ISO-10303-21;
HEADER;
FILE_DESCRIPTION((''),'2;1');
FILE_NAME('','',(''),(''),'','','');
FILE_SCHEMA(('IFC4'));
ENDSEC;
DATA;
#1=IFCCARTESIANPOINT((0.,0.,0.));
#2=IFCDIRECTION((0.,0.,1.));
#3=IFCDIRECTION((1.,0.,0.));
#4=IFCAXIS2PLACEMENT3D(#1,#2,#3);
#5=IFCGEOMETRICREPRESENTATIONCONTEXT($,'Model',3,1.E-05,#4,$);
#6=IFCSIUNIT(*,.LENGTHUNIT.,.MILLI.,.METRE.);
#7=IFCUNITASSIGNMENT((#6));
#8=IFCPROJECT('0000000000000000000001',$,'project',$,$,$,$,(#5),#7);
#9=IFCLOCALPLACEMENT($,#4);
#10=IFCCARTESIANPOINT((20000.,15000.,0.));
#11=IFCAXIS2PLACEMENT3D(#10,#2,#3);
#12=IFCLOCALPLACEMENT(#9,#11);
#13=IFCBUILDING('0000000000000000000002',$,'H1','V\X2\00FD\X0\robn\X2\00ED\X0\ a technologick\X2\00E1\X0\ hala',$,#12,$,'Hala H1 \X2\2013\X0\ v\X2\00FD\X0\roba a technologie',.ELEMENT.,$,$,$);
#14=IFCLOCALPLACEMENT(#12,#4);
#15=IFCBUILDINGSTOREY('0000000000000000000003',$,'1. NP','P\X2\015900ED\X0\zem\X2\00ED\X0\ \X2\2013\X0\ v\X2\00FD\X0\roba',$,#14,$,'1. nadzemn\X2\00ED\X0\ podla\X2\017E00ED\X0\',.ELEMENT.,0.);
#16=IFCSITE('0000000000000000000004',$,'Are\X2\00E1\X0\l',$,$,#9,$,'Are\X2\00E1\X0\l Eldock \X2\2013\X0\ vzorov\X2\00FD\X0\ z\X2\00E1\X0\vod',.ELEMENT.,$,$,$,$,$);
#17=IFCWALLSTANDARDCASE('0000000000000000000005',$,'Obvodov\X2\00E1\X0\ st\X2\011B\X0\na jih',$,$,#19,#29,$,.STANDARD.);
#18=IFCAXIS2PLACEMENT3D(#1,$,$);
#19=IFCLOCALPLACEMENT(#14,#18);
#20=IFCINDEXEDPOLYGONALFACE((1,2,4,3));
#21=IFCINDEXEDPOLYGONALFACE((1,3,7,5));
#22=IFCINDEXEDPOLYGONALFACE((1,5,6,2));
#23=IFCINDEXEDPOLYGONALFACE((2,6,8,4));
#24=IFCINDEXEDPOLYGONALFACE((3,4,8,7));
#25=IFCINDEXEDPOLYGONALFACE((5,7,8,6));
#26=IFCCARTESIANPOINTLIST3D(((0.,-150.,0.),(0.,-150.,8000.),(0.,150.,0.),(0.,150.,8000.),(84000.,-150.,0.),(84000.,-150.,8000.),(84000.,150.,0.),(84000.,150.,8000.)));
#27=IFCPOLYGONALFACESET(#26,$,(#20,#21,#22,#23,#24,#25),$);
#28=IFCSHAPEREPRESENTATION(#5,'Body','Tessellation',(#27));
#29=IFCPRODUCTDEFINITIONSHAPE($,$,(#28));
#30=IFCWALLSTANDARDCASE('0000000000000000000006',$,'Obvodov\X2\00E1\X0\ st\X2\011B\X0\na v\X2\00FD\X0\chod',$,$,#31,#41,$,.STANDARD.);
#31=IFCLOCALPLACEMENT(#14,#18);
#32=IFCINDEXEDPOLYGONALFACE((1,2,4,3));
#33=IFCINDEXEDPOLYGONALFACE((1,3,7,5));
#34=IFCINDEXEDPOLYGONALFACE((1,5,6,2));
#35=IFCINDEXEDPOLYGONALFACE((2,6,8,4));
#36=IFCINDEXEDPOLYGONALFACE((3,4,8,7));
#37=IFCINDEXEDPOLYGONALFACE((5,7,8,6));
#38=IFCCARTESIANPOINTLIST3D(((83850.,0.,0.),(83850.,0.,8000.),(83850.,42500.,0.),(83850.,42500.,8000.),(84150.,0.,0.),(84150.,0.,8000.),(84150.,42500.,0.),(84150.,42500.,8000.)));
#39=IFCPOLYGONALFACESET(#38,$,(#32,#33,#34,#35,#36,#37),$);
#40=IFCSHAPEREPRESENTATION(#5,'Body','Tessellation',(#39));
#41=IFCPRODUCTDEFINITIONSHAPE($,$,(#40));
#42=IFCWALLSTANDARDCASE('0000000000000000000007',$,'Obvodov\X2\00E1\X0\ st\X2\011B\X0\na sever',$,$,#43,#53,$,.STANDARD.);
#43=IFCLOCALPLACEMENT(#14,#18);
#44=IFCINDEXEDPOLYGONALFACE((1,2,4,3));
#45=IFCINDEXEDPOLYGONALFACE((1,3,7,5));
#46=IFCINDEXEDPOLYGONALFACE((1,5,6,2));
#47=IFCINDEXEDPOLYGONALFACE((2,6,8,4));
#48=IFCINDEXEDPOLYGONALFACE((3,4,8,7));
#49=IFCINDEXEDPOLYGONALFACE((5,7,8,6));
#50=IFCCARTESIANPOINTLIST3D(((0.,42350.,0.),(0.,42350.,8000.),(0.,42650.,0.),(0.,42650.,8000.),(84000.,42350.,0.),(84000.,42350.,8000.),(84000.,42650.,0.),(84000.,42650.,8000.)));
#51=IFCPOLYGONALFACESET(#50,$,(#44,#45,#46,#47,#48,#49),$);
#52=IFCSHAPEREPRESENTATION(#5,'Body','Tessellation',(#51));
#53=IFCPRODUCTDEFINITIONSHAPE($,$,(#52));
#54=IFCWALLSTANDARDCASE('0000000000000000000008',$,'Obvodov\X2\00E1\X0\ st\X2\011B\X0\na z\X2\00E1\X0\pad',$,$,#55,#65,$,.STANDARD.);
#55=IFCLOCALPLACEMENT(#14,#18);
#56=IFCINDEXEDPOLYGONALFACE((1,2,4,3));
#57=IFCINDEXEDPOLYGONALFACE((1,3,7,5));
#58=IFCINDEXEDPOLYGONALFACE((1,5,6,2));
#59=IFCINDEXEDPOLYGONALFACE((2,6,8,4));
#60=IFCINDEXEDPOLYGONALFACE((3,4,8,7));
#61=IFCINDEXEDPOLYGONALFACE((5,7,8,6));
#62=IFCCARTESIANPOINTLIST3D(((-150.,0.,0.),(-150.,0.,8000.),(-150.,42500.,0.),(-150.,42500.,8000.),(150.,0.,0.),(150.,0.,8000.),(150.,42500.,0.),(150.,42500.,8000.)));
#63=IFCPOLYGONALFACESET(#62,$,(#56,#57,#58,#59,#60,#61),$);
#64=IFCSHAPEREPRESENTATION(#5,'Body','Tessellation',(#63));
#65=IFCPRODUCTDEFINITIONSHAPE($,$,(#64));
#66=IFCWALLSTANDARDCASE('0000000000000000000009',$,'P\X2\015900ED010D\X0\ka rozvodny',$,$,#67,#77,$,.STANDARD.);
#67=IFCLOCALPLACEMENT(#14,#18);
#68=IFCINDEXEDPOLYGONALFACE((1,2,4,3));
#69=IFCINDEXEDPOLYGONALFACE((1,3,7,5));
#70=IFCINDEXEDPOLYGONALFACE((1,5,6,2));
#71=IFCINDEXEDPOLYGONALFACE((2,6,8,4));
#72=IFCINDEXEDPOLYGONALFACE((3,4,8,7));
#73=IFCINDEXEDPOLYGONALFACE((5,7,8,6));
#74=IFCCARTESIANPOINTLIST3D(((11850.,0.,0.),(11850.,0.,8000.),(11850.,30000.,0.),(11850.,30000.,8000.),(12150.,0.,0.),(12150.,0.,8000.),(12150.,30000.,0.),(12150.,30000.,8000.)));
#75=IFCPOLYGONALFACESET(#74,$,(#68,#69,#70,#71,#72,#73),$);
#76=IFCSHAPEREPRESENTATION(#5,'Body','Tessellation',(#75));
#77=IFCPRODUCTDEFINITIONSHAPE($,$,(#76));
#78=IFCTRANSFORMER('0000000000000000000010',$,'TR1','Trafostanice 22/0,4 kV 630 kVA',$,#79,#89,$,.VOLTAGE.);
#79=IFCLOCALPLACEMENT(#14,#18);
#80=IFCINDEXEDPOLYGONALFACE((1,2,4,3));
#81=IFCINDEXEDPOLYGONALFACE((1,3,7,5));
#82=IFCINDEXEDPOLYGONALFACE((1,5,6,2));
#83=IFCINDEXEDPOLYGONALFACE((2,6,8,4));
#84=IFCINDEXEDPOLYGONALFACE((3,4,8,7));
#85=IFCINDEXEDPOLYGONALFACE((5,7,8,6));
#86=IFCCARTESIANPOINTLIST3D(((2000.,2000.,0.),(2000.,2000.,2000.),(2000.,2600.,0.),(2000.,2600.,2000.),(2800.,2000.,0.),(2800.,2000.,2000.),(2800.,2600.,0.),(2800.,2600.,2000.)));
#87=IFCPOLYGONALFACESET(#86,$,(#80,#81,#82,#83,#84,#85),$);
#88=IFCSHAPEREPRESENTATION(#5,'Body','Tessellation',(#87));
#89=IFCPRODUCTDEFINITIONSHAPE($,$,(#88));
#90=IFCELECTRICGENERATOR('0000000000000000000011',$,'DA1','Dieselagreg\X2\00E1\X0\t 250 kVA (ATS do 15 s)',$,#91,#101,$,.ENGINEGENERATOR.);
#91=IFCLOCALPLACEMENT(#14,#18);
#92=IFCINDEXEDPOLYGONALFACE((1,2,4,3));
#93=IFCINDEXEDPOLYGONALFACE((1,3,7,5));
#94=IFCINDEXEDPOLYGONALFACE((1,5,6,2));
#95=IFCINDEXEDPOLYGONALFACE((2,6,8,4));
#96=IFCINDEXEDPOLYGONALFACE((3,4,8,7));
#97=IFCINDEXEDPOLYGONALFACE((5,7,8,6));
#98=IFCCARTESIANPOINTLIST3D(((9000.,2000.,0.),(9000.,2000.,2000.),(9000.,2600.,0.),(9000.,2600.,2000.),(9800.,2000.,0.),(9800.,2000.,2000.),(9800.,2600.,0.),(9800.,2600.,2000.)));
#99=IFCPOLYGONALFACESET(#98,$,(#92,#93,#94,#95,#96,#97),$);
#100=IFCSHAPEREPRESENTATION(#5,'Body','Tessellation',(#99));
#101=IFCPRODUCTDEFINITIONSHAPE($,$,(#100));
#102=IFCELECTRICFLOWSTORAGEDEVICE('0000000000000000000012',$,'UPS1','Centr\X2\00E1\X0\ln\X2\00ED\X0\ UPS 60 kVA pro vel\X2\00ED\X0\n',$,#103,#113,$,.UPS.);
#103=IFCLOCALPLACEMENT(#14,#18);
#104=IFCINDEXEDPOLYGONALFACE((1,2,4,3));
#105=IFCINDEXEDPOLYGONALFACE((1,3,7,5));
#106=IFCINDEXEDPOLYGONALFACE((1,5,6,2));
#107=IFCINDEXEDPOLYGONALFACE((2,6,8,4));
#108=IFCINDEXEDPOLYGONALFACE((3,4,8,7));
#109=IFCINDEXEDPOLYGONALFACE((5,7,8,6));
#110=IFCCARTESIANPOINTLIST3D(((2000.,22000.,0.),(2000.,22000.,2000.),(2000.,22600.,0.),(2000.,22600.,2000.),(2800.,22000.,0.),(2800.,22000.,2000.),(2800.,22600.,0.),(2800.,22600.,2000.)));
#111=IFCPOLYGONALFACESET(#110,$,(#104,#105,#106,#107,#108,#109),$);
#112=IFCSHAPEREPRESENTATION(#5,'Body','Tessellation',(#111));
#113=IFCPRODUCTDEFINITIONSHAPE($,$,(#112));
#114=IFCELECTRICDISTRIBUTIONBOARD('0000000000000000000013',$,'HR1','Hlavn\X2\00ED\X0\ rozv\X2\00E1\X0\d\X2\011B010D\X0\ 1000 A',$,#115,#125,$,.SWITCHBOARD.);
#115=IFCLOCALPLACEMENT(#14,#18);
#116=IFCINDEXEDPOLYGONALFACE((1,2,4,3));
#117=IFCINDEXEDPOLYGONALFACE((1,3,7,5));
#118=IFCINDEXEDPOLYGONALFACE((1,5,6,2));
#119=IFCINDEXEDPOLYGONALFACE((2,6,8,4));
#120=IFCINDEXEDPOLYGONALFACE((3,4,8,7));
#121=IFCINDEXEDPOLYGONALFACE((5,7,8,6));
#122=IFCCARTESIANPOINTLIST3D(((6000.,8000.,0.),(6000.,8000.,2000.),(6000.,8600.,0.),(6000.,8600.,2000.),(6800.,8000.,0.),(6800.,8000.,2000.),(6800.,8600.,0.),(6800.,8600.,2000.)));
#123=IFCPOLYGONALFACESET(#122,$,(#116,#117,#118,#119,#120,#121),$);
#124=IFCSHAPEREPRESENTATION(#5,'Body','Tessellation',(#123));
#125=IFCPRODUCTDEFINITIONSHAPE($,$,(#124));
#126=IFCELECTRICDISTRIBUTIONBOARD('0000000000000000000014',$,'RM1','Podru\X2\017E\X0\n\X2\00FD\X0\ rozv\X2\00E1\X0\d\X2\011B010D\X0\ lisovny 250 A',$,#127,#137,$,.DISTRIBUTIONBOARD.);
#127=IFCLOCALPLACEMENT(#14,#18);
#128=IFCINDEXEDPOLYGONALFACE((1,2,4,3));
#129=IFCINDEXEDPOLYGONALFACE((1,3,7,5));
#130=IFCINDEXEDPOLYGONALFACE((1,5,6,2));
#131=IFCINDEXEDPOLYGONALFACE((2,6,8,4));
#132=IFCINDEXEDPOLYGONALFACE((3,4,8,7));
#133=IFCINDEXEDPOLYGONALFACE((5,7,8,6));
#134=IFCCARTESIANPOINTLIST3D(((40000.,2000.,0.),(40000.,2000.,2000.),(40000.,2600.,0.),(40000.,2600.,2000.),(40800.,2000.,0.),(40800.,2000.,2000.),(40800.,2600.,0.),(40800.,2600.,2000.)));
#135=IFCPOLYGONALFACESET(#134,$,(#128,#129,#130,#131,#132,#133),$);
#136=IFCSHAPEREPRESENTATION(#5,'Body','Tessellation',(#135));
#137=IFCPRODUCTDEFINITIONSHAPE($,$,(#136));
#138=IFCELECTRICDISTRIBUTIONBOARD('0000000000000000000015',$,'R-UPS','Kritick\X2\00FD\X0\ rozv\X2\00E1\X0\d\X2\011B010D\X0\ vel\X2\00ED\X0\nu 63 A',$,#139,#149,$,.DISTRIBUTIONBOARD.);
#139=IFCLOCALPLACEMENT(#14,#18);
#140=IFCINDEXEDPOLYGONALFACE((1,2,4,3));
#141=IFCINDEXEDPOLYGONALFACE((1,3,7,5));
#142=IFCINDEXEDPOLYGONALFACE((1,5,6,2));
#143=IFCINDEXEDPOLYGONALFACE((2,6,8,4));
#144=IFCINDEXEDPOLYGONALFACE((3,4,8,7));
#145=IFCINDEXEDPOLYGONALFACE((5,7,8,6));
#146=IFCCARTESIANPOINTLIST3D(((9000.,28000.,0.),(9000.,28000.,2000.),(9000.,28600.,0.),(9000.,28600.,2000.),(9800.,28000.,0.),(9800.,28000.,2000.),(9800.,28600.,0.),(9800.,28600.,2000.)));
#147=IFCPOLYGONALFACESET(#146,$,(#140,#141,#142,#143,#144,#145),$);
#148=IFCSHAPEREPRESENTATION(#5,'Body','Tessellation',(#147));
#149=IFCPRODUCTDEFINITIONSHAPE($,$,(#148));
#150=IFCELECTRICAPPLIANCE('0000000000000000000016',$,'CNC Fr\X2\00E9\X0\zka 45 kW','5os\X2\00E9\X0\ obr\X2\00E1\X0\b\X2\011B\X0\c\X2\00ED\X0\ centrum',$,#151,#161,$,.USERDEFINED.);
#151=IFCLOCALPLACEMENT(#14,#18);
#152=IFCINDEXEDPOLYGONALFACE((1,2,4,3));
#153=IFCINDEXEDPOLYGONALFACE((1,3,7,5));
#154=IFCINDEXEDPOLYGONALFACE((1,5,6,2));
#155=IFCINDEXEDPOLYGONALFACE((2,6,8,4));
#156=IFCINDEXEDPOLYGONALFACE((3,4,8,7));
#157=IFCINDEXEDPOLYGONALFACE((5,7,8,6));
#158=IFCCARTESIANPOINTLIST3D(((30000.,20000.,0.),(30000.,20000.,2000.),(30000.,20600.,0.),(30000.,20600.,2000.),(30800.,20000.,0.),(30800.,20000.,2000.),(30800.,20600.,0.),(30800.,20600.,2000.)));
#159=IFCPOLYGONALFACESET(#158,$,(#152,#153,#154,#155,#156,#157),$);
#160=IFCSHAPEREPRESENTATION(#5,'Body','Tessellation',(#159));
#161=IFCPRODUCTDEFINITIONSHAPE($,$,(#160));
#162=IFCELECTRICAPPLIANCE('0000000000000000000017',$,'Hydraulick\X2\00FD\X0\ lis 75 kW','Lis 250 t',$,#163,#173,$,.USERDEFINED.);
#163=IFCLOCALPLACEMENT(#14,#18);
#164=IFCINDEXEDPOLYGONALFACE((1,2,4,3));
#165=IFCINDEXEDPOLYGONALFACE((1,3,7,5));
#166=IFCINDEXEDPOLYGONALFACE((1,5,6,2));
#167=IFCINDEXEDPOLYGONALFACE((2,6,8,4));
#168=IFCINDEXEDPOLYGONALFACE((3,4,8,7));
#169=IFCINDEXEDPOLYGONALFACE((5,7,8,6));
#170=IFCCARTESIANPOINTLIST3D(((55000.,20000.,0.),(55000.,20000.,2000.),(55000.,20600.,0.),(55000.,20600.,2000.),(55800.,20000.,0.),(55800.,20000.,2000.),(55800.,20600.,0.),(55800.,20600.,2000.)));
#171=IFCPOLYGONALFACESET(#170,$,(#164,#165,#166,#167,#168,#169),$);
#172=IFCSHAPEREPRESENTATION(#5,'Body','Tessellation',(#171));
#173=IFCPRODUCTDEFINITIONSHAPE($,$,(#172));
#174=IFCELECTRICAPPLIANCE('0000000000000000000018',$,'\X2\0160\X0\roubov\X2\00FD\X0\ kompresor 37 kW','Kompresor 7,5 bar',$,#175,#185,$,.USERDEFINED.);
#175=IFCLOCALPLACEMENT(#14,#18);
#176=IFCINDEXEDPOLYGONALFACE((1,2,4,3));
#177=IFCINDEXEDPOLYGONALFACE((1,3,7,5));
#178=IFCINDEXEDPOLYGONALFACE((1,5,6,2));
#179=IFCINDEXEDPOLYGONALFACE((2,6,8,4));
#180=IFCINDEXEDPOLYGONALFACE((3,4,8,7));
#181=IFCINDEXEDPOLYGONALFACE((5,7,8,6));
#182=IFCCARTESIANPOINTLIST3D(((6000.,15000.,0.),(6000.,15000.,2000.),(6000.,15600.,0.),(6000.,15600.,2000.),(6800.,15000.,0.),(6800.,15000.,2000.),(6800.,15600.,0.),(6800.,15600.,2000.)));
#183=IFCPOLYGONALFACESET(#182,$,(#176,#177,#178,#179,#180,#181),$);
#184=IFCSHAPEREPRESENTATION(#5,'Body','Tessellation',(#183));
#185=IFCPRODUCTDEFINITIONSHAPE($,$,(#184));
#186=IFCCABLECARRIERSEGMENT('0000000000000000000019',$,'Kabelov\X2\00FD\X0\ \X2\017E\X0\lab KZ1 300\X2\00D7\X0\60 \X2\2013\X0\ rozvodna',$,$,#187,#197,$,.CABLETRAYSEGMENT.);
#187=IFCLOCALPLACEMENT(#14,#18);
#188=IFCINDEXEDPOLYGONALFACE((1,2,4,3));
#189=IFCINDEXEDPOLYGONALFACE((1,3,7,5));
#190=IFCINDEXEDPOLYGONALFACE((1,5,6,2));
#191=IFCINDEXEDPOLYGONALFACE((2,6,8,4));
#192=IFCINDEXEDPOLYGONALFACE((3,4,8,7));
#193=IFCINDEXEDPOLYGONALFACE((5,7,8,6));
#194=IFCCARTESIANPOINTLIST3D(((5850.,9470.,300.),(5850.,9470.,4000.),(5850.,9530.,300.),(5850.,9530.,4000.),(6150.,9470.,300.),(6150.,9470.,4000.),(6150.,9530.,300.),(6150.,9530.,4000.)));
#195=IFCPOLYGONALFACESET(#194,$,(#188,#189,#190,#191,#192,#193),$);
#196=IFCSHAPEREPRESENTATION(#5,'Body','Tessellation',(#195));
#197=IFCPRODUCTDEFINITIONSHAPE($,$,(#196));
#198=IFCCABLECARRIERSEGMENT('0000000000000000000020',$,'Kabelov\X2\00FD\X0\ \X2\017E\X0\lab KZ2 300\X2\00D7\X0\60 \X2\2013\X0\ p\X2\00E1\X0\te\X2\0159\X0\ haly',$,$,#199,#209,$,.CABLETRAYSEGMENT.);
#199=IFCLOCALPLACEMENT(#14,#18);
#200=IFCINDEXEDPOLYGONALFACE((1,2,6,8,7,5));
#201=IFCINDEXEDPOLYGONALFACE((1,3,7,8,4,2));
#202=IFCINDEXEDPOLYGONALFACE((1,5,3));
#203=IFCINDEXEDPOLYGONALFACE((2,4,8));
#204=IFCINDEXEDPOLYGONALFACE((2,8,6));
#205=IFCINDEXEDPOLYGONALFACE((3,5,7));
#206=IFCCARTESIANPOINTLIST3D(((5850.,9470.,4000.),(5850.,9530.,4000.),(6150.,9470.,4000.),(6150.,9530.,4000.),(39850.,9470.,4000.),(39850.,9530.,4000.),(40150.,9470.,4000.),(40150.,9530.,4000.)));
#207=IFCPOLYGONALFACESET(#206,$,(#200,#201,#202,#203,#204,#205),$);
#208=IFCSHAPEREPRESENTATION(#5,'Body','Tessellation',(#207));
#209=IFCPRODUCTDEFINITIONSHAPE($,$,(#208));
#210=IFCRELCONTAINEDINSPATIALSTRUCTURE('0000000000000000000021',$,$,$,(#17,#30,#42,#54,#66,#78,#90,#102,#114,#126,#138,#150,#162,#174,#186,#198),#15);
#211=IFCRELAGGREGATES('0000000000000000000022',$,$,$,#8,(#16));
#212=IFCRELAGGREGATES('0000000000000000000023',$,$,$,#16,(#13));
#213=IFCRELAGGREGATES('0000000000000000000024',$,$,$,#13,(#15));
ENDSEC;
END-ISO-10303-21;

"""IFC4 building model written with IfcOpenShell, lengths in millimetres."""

from ifc_helpers import new_model, si_unit, frame, frame_2d, origin_with_axes, origin_2d, place, context, project, spatial, rectangle, extrude, element, save


model = new_model("IFC4")

# Units and contexts
model_context = context("Model", 3, precision=1e-05, world=origin_with_axes())
ifc_project = project(units=[si_unit("LENGTHUNIT", "METRE", prefix="MILLI")], contexts=[model_context])

# Site, building, storey
site_placement = place(None, origin_with_axes())
site = spatial("IfcSite", under=ifc_project, at=site_placement, Name="Areál", LongName="Areál Eldock – vzorový závod", CompositionType="ELEMENT")
building_placement = place(site_placement, frame((20000.0, 15000.0, 0.0), z_axis=(0.0, 0.0, 1.0), x_axis=(1.0, 0.0, 0.0)))
building = spatial("IfcBuilding", under=site, at=building_placement, Name="H1", Description="Výrobní a technologická hala", LongName="Hala H1 – výroba a technologie", CompositionType="ELEMENT")
storey_placement = place(building_placement, origin_with_axes())
storey = spatial("IfcBuildingStorey", under=building, at=storey_placement, Name="1. NP", Description="Přízemí – výroba", LongName="1. nadzemní podlaží", CompositionType="ELEMENT", Elevation=0.0)

# Walls
wall_1_placement = place(storey_placement, origin_with_axes())
element("IfcWallStandardCase", 1, at=wall_1_placement, inside=storey, Name="Obvodová stěna jih", PredefinedType="STANDARD", context=model_context, shape_type="SweptSolid", body=[
    extrude(rectangle(XDim=84000.0, YDim=300.0, at=frame_2d((42000.0, 0.0))), origin_with_axes(), (0.0, 0.0, 1.0), 8000.0),
])
wall_2_placement = place(storey_placement, frame((84000.0, 0.0, 0.0), z_axis=(0.0, 0.0, 1.0), x_axis=(0.0, 1.0, 0.0)))
element("IfcWallStandardCase", 2, at=wall_2_placement, inside=storey, Name="Obvodová stěna východ", PredefinedType="STANDARD", context=model_context, shape_type="SweptSolid", body=[
    extrude(rectangle(XDim=42500.0, YDim=300.0, at=frame_2d((21250.0, 0.0))), origin_with_axes(), (0.0, 0.0, 1.0), 8000.0),
])
wall_3_placement = place(storey_placement, frame((84000.0, 42500.0, 0.0), z_axis=(0.0, 0.0, 1.0), x_axis=(-1.0, 0.0, 0.0)))
element("IfcWallStandardCase", 3, at=wall_3_placement, inside=storey, Name="Obvodová stěna sever", PredefinedType="STANDARD", context=model_context, shape_type="SweptSolid", body=[
    extrude(rectangle(XDim=84000.0, YDim=300.0, at=frame_2d((42000.0, 0.0))), origin_with_axes(), (0.0, 0.0, 1.0), 8000.0),
])
wall_4_placement = place(storey_placement, frame((0.0, 42500.0, 0.0), z_axis=(0.0, 0.0, 1.0), x_axis=(0.0, -1.0, 0.0)))
element("IfcWallStandardCase", 4, at=wall_4_placement, inside=storey, Name="Obvodová stěna západ", PredefinedType="STANDARD", context=model_context, shape_type="SweptSolid", body=[
    extrude(rectangle(XDim=42500.0, YDim=300.0, at=frame_2d((21250.0, 0.0))), origin_with_axes(), (0.0, 0.0, 1.0), 8000.0),
])
wall_5_placement = place(storey_placement, frame((12000.0, 0.0, 0.0), z_axis=(0.0, 0.0, 1.0), x_axis=(0.0, 1.0, 0.0)))
element("IfcWallStandardCase", 5, at=wall_5_placement, inside=storey, Name="Příčka rozvodny", PredefinedType="STANDARD", context=model_context, shape_type="SweptSolid", body=[
    extrude(rectangle(XDim=30000.0, YDim=300.0, at=frame_2d((15000.0, 0.0))), origin_with_axes(), (0.0, 0.0, 1.0), 8000.0),
])

# Transformer
transformer_placement = place(storey_placement, frame((2000.0, 2000.0, 0.0), z_axis=(0.0, 0.0, 1.0), x_axis=(1.0, 0.0, 0.0)))
element("IfcTransformer", 6, at=transformer_placement, inside=storey, Name="TR1", Description="Trafostanice 22/0,4 kV 630 kVA", PredefinedType="VOLTAGE", context=model_context, shape_type="SweptSolid", body=[
    extrude(rectangle(XDim=800.0, YDim=600.0, at=frame_2d((400.0, 300.0))), origin_with_axes(), (0.0, 0.0, 1.0), 2000.0),
])

# Electric generator
electric_generator_placement = place(storey_placement, frame((9000.0, 2000.0, 0.0), z_axis=(0.0, 0.0, 1.0), x_axis=(1.0, 0.0, 0.0)))
element("IfcElectricGenerator", 7, at=electric_generator_placement, inside=storey, Name="DA1", Description="Dieselagregát 250 kVA (ATS do 15 s)", PredefinedType="ENGINEGENERATOR", context=model_context, shape_type="SweptSolid", body=[
    extrude(rectangle(XDim=800.0, YDim=600.0, at=frame_2d((400.0, 300.0))), origin_with_axes(), (0.0, 0.0, 1.0), 2000.0),
])

# Electric flow storage device
placement = place(storey_placement, frame((0.0, 20000.0, 0.0), z_axis=(0.0, 0.0, 1.0), x_axis=(1.0, 0.0, 0.0)))
electric_flow_storage_device_placement = place(placement, frame((2000.0, 2000.0, 0.0), z_axis=(0.0, 0.0, 1.0), x_axis=(1.0, 0.0, 0.0)))
element("IfcElectricFlowStorageDevice", 8, at=electric_flow_storage_device_placement, inside=storey, Name="UPS1", Description="Centrální UPS 60 kVA pro velín", PredefinedType="UPS", context=model_context, shape_type="SweptSolid", body=[
    extrude(rectangle(XDim=800.0, YDim=600.0, at=frame_2d((400.0, 300.0))), origin_with_axes(), (0.0, 0.0, 1.0), 2000.0),
])

# Electric distribution boards
electric_distribution_board_1_placement = place(storey_placement, frame((6000.0, 8000.0, 0.0), z_axis=(0.0, 0.0, 1.0), x_axis=(1.0, 0.0, 0.0)))
element("IfcElectricDistributionBoard", 9, at=electric_distribution_board_1_placement, inside=storey, Name="HR1", Description="Hlavní rozváděč 1000 A", PredefinedType="SWITCHBOARD", context=model_context, shape_type="SweptSolid", body=[
    extrude(rectangle(XDim=800.0, YDim=600.0, at=frame_2d((400.0, 300.0))), origin_with_axes(), (0.0, 0.0, 1.0), 2000.0),
])
electric_distribution_board_2_placement = place(storey_placement, frame((40000.0, 2000.0, 0.0), z_axis=(0.0, 0.0, 1.0), x_axis=(1.0, 0.0, 0.0)))
element("IfcElectricDistributionBoard", 10, at=electric_distribution_board_2_placement, inside=storey, Name="RM1", Description="Podružný rozváděč lisovny 250 A", PredefinedType="DISTRIBUTIONBOARD", context=model_context, shape_type="SweptSolid", body=[
    extrude(rectangle(XDim=800.0, YDim=600.0, at=frame_2d((400.0, 300.0))), origin_with_axes(), (0.0, 0.0, 1.0), 2000.0),
])
electric_distribution_board_3_placement = place(placement, frame((9000.0, 8000.0, 0.0), z_axis=(0.0, 0.0, 1.0), x_axis=(1.0, 0.0, 0.0)))
element("IfcElectricDistributionBoard", 11, at=electric_distribution_board_3_placement, inside=storey, Name="R-UPS", Description="Kritický rozváděč velínu 63 A", PredefinedType="DISTRIBUTIONBOARD", context=model_context, shape_type="SweptSolid", body=[
    extrude(rectangle(XDim=800.0, YDim=600.0, at=frame_2d((400.0, 300.0))), origin_with_axes(), (0.0, 0.0, 1.0), 2000.0),
])

# Electric appliances
for number, where, z_axis, x_axis, name, description in (
    (12, (30000.0, 20000.0, 0.0), (0.0, 0.0, 1.0), (1.0, 0.0, 0.0), "CNC Frézka 45 kW", "5osé obráběcí centrum"),
    (13, (55000.0, 20000.0, 0.0), (0.0, 0.0, 1.0), (1.0, 0.0, 0.0), "Hydraulický lis 75 kW", "Lis 250 t"),
    (14, (6000.0, 15000.0, 0.0), (0.0, 0.0, 1.0), (1.0, 0.0, 0.0), "Šroubový kompresor 37 kW", "Kompresor 7,5 bar"),
):
    element("IfcElectricAppliance", number, at=place(storey_placement, frame(where, z_axis=z_axis, x_axis=x_axis)), inside=storey, Name=name, Description=description, PredefinedType="USERDEFINED", context=model_context, shape_type="SweptSolid", body=[
        extrude(rectangle(XDim=800.0, YDim=600.0, at=frame_2d((400.0, 300.0))), origin_with_axes(), (0.0, 0.0, 1.0), 2000.0),
    ])

# Cable carrier segments
cable_carrier_segment_1_placement = place(storey_placement, frame((6000.0, 9500.0, 300.0), z_axis=(0.0, 0.0, 1.0), x_axis=(1.0, 0.0, 0.0)))
element("IfcCableCarrierSegment", 15, at=cable_carrier_segment_1_placement, inside=storey, Name="Kabelový žlab KZ1 300×60 – rozvodna", PredefinedType="CABLETRAYSEGMENT", context=model_context, shape_type="SweptSolid", body=[
    extrude(rectangle(XDim=300.0, YDim=60.0, at=origin_2d()), origin_with_axes(), (0.0, 0.0, 1.0), 3700.0),
])
cable_carrier_segment_2_placement = place(storey_placement, frame((6000.0, 9500.0, 4000.0), z_axis=(0.0, 0.0, 1.0), x_axis=(1.0, 0.0, 0.0)))
element("IfcCableCarrierSegment", 16, at=cable_carrier_segment_2_placement, inside=storey, Name="Kabelový žlab KZ2 300×60 – páteř haly", PredefinedType="CABLETRAYSEGMENT", context=model_context, shape_type="SweptSolid", body=[
    extrude(rectangle(XDim=300.0, YDim=60.0, at=origin_2d()), origin_with_axes(), (1.0, 0.0, 0.0), 34000.0),
])

save(model, "model.ifc")
